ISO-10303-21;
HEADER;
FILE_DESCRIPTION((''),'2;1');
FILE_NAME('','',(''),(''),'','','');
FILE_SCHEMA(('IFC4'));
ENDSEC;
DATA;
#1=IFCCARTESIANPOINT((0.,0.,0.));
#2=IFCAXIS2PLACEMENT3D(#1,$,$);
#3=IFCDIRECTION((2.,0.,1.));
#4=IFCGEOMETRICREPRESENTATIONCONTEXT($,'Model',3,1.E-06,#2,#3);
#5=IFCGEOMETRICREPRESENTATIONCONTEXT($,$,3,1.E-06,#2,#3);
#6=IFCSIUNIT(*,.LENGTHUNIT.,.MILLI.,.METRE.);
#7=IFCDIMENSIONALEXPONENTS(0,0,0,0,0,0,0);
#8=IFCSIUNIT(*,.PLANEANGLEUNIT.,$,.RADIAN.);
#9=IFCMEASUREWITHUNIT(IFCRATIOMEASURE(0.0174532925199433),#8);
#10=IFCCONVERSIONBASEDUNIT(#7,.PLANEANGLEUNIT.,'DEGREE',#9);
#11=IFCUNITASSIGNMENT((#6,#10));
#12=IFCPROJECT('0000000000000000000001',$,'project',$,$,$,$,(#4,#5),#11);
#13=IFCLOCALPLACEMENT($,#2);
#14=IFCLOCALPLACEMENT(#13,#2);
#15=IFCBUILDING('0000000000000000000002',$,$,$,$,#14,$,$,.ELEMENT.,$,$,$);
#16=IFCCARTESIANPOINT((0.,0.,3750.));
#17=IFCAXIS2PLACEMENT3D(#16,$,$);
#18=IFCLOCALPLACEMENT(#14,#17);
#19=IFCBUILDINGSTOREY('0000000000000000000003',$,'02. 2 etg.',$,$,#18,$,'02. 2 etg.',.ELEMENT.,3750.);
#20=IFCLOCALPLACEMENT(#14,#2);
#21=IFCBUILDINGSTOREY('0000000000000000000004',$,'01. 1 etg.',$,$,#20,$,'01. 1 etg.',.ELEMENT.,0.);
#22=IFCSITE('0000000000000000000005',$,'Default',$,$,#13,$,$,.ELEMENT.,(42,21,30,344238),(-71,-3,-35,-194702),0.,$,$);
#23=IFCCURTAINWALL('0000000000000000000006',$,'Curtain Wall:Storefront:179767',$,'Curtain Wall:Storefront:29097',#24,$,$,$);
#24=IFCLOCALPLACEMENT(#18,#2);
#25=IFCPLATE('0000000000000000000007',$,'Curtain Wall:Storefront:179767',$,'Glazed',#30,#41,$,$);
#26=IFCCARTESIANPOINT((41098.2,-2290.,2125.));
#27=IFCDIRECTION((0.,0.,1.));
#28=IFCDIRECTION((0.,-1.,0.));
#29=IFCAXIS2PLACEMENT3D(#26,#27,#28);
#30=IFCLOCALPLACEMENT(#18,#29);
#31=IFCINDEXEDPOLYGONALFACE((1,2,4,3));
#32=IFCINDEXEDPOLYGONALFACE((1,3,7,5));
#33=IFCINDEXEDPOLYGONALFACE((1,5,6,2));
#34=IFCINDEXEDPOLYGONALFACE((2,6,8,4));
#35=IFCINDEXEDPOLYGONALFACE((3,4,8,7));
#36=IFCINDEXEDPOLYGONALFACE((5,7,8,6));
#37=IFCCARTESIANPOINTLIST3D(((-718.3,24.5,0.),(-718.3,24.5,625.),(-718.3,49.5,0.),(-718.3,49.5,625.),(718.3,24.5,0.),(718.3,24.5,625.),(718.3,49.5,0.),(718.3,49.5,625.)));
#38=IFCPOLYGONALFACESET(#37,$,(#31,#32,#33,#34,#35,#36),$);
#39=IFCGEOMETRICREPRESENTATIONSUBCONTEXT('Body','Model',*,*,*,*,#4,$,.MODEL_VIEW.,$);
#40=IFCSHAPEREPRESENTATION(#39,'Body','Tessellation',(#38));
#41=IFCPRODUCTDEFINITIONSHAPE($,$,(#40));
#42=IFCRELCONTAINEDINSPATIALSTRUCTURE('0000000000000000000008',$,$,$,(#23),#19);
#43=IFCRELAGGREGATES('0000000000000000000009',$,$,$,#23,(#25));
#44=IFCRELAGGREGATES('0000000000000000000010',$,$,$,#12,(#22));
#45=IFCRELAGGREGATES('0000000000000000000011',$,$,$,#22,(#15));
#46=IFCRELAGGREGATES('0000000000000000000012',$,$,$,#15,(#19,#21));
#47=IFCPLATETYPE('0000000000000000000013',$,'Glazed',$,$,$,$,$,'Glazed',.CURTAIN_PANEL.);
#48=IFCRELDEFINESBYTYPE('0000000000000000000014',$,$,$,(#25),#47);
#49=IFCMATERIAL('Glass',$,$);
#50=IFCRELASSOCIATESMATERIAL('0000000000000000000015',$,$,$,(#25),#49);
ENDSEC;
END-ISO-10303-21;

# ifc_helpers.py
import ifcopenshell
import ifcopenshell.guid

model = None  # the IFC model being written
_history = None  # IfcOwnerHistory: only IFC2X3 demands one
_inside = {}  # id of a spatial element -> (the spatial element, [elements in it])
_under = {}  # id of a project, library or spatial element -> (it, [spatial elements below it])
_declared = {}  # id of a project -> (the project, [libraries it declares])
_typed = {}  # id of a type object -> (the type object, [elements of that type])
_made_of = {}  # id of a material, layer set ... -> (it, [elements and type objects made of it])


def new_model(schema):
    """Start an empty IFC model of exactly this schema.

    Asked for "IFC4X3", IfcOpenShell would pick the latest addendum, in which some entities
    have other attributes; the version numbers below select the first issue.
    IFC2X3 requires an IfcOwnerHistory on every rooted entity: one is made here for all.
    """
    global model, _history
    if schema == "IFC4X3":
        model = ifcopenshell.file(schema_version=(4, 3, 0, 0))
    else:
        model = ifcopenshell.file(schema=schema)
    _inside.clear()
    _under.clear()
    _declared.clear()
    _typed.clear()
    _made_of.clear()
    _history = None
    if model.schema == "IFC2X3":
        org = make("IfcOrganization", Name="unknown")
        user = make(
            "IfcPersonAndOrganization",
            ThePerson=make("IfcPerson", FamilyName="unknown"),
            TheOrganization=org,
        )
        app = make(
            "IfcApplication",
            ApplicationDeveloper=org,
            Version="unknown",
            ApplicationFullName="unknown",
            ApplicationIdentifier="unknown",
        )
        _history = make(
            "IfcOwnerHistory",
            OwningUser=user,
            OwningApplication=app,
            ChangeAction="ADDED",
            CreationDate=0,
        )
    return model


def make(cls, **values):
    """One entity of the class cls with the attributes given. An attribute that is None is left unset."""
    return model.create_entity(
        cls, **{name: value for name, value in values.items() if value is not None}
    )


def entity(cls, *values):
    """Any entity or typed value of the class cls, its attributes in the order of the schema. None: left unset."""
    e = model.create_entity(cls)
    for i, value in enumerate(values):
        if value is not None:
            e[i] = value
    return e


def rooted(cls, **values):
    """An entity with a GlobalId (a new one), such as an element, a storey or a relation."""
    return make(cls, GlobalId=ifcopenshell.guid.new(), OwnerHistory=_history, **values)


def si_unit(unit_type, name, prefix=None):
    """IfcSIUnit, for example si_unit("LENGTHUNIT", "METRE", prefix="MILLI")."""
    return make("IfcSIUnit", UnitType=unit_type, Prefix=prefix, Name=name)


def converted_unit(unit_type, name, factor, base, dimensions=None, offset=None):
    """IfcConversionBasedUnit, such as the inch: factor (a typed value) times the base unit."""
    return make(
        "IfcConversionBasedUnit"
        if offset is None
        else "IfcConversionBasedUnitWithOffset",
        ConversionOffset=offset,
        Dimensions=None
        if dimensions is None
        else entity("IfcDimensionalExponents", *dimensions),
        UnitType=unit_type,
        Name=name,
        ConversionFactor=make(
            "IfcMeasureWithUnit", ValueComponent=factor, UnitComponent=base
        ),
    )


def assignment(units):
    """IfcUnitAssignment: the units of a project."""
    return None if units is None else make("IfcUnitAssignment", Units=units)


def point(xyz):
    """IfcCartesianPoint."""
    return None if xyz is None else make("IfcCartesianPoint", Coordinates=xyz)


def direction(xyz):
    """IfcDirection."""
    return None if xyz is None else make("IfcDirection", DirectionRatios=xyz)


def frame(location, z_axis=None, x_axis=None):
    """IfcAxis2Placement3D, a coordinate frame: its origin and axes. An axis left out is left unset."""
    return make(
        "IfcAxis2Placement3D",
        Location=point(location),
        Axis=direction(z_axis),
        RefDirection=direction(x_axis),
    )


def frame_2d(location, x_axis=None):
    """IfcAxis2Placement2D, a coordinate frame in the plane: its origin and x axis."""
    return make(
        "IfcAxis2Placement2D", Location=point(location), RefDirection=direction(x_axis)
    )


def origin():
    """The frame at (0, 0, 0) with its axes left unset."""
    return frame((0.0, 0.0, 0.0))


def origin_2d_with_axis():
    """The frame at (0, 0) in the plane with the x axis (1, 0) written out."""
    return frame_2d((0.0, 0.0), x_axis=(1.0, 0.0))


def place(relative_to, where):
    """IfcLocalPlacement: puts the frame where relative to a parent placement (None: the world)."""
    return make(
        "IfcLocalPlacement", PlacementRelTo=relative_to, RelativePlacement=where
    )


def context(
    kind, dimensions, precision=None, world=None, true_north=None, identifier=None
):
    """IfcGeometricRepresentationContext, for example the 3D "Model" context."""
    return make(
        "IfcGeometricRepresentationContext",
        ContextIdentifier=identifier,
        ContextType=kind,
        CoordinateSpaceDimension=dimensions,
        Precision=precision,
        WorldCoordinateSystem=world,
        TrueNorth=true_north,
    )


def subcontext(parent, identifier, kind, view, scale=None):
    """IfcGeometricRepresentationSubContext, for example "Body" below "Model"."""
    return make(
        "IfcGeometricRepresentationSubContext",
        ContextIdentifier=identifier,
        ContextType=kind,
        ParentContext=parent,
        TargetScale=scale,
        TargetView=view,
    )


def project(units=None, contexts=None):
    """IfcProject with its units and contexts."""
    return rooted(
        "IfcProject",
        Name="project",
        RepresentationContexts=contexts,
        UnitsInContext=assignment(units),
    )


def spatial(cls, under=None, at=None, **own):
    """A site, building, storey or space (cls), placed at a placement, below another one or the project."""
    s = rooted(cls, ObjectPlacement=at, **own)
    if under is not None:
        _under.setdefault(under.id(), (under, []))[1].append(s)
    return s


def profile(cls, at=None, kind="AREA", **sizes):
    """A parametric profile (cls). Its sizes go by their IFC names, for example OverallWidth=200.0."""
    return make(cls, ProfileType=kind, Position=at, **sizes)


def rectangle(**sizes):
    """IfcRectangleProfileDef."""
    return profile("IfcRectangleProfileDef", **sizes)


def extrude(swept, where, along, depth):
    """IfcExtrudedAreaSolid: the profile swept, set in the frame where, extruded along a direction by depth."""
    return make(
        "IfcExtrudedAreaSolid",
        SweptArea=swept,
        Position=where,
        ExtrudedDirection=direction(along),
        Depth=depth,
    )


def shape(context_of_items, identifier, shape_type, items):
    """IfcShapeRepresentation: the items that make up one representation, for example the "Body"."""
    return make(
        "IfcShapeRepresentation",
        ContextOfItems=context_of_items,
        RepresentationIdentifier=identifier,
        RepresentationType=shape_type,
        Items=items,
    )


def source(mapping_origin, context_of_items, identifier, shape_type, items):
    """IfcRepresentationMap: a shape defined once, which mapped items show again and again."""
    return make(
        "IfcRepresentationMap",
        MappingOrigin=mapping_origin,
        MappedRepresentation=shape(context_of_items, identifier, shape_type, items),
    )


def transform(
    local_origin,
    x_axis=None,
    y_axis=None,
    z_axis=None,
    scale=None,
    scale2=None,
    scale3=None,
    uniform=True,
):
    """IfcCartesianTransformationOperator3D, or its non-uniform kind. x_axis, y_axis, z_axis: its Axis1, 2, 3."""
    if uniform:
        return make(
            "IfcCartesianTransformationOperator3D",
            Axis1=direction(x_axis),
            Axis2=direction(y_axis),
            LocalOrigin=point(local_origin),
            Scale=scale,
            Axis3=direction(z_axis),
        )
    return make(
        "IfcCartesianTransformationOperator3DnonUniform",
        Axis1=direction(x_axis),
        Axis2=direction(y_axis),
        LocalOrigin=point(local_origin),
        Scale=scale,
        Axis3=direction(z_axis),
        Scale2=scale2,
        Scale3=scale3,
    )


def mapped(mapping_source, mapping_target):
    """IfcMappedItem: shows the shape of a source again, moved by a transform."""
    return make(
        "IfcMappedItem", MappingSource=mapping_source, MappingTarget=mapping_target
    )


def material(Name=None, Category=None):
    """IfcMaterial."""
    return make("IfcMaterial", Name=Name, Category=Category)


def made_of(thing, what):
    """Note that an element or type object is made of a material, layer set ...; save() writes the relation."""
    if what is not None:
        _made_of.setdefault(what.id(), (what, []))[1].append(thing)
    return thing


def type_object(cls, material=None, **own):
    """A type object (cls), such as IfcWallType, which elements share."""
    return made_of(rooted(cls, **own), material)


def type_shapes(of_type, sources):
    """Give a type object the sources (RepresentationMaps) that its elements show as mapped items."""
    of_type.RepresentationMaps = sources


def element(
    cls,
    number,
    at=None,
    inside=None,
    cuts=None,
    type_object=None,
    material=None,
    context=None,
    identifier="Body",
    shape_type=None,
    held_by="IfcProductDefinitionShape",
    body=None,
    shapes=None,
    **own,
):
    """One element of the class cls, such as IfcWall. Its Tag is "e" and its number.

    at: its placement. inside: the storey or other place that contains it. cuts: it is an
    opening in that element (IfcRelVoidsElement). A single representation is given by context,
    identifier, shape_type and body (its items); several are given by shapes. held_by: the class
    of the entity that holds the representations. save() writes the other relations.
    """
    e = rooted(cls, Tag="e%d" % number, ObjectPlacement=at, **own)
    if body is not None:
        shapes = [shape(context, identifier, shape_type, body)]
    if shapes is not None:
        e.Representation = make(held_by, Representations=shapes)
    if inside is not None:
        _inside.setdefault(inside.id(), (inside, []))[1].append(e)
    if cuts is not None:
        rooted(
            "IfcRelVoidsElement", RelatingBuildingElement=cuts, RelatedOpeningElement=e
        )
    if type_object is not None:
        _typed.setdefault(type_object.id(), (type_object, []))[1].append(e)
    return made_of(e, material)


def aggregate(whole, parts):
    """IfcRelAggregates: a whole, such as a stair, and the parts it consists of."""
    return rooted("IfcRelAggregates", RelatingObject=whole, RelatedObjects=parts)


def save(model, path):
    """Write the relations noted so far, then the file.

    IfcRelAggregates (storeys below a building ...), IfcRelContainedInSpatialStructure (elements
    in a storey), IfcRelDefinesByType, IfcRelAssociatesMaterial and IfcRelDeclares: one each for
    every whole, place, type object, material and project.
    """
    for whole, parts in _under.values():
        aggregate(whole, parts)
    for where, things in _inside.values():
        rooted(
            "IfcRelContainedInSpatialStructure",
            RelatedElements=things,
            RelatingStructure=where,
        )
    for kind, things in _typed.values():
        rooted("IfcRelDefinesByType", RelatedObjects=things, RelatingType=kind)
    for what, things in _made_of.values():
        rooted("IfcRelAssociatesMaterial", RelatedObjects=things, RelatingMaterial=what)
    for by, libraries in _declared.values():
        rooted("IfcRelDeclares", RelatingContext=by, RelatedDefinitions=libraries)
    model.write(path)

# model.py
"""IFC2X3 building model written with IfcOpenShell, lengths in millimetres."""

from ifc_helpers import new_model, entity, si_unit, converted_unit, direction, frame, origin, origin_2d_with_axis, place, context, subcontext, project, spatial, rectangle, extrude, source, transform, mapped, material, type_object, type_shapes, element, aggregate, save


model = new_model("IFC2X3")

# Units and contexts
model_context = context("Model", 3, precision=1e-06, world=origin(), true_north=direction((2.0, 0.0, 1.0)))
context_of_model = context(None, 3, precision=1e-06, world=origin(), true_north=direction((2.0, 0.0, 1.0)))
body_context = subcontext(model_context, "Body", "Model", "MODEL_VIEW")
ifc_project = project(units=[si_unit("LENGTHUNIT", "METRE", prefix="MILLI"), converted_unit("PLANEANGLEUNIT", "DEGREE", entity("IfcRatioMeasure", 0.0174532925199433), si_unit("PLANEANGLEUNIT", "RADIAN"), dimensions=[0, 0, 0, 0, 0, 0, 0])], contexts=[model_context, context_of_model])

# Site, building, storey
site_placement = place(None, origin())
site = spatial("IfcSite", under=ifc_project, at=site_placement, Name="Default", CompositionType="ELEMENT", RefLatitude=(42, 21, 30, 344238), RefLongitude=(-71, -3, -35, -194702), RefElevation=0.0)
building_placement = place(site_placement, origin())
building = spatial("IfcBuilding", under=site, at=building_placement, CompositionType="ELEMENT")
storey_1_placement = place(building_placement, frame((0.0, 0.0, 3750.0)))
storey_1 = spatial("IfcBuildingStorey", under=building, at=storey_1_placement, Name="02. 2 etg.", LongName="02. 2 etg.", CompositionType="ELEMENT", Elevation=3750.0)

# Curtain wall
ifc_material_1 = material(Name="Glass")
curtain_wall_1_placement = place(storey_1_placement, origin())
curtain_wall_1 = element("IfcCurtainWall", 1, at=curtain_wall_1_placement, inside=storey_1, Name="Curtain Wall:Storefront:179767", ObjectType="Curtain Wall:Storefront:29097")
storey_2_placement = place(building_placement, origin())

# Plate
plate_type_1 = type_object("IfcPlateType", Name="Glazed", ElementType="Glazed", PredefinedType="CURTAIN_PANEL")
shared_shape_1 = source(origin(), body_context, "Body", "SweptSolid", [
    extrude(rectangle(XDim=25.0, YDim=1436.7, at=origin_2d_with_axis()), frame((0.0, 37.0, 0.0), z_axis=(0.0, 0.0, 1.0), x_axis=(0.0, 1.0, 0.0)), (0.0, 0.0, 1.0), 625.0),
])
type_shapes(plate_type_1, [shared_shape_1])
plate_1_placement = place(storey_1_placement, frame((41098.2, -2290.0, 2125.0), z_axis=(0.0, 0.0, 1.0), x_axis=(0.0, -1.0, 0.0)))
plate_1 = element("IfcPlate", 2, at=plate_1_placement, type_object=plate_type_1, material=ifc_material_1, Name="Curtain Wall:Storefront:179767", ObjectType="Glazed", context=body_context, shape_type="MappedRepresentation", body=[
    mapped(shared_shape_1, transform((0.0, 0.0, 0.0), scale=1.0)),
])
aggregate(curtain_wall_1, [plate_1])

# Shared definitions
storey_2 = spatial("IfcBuildingStorey", under=building, at=storey_2_placement, Name="01. 1 etg.", LongName="01. 1 etg.", CompositionType="ELEMENT", Elevation=0.0)

save(model, "model.ifc")
